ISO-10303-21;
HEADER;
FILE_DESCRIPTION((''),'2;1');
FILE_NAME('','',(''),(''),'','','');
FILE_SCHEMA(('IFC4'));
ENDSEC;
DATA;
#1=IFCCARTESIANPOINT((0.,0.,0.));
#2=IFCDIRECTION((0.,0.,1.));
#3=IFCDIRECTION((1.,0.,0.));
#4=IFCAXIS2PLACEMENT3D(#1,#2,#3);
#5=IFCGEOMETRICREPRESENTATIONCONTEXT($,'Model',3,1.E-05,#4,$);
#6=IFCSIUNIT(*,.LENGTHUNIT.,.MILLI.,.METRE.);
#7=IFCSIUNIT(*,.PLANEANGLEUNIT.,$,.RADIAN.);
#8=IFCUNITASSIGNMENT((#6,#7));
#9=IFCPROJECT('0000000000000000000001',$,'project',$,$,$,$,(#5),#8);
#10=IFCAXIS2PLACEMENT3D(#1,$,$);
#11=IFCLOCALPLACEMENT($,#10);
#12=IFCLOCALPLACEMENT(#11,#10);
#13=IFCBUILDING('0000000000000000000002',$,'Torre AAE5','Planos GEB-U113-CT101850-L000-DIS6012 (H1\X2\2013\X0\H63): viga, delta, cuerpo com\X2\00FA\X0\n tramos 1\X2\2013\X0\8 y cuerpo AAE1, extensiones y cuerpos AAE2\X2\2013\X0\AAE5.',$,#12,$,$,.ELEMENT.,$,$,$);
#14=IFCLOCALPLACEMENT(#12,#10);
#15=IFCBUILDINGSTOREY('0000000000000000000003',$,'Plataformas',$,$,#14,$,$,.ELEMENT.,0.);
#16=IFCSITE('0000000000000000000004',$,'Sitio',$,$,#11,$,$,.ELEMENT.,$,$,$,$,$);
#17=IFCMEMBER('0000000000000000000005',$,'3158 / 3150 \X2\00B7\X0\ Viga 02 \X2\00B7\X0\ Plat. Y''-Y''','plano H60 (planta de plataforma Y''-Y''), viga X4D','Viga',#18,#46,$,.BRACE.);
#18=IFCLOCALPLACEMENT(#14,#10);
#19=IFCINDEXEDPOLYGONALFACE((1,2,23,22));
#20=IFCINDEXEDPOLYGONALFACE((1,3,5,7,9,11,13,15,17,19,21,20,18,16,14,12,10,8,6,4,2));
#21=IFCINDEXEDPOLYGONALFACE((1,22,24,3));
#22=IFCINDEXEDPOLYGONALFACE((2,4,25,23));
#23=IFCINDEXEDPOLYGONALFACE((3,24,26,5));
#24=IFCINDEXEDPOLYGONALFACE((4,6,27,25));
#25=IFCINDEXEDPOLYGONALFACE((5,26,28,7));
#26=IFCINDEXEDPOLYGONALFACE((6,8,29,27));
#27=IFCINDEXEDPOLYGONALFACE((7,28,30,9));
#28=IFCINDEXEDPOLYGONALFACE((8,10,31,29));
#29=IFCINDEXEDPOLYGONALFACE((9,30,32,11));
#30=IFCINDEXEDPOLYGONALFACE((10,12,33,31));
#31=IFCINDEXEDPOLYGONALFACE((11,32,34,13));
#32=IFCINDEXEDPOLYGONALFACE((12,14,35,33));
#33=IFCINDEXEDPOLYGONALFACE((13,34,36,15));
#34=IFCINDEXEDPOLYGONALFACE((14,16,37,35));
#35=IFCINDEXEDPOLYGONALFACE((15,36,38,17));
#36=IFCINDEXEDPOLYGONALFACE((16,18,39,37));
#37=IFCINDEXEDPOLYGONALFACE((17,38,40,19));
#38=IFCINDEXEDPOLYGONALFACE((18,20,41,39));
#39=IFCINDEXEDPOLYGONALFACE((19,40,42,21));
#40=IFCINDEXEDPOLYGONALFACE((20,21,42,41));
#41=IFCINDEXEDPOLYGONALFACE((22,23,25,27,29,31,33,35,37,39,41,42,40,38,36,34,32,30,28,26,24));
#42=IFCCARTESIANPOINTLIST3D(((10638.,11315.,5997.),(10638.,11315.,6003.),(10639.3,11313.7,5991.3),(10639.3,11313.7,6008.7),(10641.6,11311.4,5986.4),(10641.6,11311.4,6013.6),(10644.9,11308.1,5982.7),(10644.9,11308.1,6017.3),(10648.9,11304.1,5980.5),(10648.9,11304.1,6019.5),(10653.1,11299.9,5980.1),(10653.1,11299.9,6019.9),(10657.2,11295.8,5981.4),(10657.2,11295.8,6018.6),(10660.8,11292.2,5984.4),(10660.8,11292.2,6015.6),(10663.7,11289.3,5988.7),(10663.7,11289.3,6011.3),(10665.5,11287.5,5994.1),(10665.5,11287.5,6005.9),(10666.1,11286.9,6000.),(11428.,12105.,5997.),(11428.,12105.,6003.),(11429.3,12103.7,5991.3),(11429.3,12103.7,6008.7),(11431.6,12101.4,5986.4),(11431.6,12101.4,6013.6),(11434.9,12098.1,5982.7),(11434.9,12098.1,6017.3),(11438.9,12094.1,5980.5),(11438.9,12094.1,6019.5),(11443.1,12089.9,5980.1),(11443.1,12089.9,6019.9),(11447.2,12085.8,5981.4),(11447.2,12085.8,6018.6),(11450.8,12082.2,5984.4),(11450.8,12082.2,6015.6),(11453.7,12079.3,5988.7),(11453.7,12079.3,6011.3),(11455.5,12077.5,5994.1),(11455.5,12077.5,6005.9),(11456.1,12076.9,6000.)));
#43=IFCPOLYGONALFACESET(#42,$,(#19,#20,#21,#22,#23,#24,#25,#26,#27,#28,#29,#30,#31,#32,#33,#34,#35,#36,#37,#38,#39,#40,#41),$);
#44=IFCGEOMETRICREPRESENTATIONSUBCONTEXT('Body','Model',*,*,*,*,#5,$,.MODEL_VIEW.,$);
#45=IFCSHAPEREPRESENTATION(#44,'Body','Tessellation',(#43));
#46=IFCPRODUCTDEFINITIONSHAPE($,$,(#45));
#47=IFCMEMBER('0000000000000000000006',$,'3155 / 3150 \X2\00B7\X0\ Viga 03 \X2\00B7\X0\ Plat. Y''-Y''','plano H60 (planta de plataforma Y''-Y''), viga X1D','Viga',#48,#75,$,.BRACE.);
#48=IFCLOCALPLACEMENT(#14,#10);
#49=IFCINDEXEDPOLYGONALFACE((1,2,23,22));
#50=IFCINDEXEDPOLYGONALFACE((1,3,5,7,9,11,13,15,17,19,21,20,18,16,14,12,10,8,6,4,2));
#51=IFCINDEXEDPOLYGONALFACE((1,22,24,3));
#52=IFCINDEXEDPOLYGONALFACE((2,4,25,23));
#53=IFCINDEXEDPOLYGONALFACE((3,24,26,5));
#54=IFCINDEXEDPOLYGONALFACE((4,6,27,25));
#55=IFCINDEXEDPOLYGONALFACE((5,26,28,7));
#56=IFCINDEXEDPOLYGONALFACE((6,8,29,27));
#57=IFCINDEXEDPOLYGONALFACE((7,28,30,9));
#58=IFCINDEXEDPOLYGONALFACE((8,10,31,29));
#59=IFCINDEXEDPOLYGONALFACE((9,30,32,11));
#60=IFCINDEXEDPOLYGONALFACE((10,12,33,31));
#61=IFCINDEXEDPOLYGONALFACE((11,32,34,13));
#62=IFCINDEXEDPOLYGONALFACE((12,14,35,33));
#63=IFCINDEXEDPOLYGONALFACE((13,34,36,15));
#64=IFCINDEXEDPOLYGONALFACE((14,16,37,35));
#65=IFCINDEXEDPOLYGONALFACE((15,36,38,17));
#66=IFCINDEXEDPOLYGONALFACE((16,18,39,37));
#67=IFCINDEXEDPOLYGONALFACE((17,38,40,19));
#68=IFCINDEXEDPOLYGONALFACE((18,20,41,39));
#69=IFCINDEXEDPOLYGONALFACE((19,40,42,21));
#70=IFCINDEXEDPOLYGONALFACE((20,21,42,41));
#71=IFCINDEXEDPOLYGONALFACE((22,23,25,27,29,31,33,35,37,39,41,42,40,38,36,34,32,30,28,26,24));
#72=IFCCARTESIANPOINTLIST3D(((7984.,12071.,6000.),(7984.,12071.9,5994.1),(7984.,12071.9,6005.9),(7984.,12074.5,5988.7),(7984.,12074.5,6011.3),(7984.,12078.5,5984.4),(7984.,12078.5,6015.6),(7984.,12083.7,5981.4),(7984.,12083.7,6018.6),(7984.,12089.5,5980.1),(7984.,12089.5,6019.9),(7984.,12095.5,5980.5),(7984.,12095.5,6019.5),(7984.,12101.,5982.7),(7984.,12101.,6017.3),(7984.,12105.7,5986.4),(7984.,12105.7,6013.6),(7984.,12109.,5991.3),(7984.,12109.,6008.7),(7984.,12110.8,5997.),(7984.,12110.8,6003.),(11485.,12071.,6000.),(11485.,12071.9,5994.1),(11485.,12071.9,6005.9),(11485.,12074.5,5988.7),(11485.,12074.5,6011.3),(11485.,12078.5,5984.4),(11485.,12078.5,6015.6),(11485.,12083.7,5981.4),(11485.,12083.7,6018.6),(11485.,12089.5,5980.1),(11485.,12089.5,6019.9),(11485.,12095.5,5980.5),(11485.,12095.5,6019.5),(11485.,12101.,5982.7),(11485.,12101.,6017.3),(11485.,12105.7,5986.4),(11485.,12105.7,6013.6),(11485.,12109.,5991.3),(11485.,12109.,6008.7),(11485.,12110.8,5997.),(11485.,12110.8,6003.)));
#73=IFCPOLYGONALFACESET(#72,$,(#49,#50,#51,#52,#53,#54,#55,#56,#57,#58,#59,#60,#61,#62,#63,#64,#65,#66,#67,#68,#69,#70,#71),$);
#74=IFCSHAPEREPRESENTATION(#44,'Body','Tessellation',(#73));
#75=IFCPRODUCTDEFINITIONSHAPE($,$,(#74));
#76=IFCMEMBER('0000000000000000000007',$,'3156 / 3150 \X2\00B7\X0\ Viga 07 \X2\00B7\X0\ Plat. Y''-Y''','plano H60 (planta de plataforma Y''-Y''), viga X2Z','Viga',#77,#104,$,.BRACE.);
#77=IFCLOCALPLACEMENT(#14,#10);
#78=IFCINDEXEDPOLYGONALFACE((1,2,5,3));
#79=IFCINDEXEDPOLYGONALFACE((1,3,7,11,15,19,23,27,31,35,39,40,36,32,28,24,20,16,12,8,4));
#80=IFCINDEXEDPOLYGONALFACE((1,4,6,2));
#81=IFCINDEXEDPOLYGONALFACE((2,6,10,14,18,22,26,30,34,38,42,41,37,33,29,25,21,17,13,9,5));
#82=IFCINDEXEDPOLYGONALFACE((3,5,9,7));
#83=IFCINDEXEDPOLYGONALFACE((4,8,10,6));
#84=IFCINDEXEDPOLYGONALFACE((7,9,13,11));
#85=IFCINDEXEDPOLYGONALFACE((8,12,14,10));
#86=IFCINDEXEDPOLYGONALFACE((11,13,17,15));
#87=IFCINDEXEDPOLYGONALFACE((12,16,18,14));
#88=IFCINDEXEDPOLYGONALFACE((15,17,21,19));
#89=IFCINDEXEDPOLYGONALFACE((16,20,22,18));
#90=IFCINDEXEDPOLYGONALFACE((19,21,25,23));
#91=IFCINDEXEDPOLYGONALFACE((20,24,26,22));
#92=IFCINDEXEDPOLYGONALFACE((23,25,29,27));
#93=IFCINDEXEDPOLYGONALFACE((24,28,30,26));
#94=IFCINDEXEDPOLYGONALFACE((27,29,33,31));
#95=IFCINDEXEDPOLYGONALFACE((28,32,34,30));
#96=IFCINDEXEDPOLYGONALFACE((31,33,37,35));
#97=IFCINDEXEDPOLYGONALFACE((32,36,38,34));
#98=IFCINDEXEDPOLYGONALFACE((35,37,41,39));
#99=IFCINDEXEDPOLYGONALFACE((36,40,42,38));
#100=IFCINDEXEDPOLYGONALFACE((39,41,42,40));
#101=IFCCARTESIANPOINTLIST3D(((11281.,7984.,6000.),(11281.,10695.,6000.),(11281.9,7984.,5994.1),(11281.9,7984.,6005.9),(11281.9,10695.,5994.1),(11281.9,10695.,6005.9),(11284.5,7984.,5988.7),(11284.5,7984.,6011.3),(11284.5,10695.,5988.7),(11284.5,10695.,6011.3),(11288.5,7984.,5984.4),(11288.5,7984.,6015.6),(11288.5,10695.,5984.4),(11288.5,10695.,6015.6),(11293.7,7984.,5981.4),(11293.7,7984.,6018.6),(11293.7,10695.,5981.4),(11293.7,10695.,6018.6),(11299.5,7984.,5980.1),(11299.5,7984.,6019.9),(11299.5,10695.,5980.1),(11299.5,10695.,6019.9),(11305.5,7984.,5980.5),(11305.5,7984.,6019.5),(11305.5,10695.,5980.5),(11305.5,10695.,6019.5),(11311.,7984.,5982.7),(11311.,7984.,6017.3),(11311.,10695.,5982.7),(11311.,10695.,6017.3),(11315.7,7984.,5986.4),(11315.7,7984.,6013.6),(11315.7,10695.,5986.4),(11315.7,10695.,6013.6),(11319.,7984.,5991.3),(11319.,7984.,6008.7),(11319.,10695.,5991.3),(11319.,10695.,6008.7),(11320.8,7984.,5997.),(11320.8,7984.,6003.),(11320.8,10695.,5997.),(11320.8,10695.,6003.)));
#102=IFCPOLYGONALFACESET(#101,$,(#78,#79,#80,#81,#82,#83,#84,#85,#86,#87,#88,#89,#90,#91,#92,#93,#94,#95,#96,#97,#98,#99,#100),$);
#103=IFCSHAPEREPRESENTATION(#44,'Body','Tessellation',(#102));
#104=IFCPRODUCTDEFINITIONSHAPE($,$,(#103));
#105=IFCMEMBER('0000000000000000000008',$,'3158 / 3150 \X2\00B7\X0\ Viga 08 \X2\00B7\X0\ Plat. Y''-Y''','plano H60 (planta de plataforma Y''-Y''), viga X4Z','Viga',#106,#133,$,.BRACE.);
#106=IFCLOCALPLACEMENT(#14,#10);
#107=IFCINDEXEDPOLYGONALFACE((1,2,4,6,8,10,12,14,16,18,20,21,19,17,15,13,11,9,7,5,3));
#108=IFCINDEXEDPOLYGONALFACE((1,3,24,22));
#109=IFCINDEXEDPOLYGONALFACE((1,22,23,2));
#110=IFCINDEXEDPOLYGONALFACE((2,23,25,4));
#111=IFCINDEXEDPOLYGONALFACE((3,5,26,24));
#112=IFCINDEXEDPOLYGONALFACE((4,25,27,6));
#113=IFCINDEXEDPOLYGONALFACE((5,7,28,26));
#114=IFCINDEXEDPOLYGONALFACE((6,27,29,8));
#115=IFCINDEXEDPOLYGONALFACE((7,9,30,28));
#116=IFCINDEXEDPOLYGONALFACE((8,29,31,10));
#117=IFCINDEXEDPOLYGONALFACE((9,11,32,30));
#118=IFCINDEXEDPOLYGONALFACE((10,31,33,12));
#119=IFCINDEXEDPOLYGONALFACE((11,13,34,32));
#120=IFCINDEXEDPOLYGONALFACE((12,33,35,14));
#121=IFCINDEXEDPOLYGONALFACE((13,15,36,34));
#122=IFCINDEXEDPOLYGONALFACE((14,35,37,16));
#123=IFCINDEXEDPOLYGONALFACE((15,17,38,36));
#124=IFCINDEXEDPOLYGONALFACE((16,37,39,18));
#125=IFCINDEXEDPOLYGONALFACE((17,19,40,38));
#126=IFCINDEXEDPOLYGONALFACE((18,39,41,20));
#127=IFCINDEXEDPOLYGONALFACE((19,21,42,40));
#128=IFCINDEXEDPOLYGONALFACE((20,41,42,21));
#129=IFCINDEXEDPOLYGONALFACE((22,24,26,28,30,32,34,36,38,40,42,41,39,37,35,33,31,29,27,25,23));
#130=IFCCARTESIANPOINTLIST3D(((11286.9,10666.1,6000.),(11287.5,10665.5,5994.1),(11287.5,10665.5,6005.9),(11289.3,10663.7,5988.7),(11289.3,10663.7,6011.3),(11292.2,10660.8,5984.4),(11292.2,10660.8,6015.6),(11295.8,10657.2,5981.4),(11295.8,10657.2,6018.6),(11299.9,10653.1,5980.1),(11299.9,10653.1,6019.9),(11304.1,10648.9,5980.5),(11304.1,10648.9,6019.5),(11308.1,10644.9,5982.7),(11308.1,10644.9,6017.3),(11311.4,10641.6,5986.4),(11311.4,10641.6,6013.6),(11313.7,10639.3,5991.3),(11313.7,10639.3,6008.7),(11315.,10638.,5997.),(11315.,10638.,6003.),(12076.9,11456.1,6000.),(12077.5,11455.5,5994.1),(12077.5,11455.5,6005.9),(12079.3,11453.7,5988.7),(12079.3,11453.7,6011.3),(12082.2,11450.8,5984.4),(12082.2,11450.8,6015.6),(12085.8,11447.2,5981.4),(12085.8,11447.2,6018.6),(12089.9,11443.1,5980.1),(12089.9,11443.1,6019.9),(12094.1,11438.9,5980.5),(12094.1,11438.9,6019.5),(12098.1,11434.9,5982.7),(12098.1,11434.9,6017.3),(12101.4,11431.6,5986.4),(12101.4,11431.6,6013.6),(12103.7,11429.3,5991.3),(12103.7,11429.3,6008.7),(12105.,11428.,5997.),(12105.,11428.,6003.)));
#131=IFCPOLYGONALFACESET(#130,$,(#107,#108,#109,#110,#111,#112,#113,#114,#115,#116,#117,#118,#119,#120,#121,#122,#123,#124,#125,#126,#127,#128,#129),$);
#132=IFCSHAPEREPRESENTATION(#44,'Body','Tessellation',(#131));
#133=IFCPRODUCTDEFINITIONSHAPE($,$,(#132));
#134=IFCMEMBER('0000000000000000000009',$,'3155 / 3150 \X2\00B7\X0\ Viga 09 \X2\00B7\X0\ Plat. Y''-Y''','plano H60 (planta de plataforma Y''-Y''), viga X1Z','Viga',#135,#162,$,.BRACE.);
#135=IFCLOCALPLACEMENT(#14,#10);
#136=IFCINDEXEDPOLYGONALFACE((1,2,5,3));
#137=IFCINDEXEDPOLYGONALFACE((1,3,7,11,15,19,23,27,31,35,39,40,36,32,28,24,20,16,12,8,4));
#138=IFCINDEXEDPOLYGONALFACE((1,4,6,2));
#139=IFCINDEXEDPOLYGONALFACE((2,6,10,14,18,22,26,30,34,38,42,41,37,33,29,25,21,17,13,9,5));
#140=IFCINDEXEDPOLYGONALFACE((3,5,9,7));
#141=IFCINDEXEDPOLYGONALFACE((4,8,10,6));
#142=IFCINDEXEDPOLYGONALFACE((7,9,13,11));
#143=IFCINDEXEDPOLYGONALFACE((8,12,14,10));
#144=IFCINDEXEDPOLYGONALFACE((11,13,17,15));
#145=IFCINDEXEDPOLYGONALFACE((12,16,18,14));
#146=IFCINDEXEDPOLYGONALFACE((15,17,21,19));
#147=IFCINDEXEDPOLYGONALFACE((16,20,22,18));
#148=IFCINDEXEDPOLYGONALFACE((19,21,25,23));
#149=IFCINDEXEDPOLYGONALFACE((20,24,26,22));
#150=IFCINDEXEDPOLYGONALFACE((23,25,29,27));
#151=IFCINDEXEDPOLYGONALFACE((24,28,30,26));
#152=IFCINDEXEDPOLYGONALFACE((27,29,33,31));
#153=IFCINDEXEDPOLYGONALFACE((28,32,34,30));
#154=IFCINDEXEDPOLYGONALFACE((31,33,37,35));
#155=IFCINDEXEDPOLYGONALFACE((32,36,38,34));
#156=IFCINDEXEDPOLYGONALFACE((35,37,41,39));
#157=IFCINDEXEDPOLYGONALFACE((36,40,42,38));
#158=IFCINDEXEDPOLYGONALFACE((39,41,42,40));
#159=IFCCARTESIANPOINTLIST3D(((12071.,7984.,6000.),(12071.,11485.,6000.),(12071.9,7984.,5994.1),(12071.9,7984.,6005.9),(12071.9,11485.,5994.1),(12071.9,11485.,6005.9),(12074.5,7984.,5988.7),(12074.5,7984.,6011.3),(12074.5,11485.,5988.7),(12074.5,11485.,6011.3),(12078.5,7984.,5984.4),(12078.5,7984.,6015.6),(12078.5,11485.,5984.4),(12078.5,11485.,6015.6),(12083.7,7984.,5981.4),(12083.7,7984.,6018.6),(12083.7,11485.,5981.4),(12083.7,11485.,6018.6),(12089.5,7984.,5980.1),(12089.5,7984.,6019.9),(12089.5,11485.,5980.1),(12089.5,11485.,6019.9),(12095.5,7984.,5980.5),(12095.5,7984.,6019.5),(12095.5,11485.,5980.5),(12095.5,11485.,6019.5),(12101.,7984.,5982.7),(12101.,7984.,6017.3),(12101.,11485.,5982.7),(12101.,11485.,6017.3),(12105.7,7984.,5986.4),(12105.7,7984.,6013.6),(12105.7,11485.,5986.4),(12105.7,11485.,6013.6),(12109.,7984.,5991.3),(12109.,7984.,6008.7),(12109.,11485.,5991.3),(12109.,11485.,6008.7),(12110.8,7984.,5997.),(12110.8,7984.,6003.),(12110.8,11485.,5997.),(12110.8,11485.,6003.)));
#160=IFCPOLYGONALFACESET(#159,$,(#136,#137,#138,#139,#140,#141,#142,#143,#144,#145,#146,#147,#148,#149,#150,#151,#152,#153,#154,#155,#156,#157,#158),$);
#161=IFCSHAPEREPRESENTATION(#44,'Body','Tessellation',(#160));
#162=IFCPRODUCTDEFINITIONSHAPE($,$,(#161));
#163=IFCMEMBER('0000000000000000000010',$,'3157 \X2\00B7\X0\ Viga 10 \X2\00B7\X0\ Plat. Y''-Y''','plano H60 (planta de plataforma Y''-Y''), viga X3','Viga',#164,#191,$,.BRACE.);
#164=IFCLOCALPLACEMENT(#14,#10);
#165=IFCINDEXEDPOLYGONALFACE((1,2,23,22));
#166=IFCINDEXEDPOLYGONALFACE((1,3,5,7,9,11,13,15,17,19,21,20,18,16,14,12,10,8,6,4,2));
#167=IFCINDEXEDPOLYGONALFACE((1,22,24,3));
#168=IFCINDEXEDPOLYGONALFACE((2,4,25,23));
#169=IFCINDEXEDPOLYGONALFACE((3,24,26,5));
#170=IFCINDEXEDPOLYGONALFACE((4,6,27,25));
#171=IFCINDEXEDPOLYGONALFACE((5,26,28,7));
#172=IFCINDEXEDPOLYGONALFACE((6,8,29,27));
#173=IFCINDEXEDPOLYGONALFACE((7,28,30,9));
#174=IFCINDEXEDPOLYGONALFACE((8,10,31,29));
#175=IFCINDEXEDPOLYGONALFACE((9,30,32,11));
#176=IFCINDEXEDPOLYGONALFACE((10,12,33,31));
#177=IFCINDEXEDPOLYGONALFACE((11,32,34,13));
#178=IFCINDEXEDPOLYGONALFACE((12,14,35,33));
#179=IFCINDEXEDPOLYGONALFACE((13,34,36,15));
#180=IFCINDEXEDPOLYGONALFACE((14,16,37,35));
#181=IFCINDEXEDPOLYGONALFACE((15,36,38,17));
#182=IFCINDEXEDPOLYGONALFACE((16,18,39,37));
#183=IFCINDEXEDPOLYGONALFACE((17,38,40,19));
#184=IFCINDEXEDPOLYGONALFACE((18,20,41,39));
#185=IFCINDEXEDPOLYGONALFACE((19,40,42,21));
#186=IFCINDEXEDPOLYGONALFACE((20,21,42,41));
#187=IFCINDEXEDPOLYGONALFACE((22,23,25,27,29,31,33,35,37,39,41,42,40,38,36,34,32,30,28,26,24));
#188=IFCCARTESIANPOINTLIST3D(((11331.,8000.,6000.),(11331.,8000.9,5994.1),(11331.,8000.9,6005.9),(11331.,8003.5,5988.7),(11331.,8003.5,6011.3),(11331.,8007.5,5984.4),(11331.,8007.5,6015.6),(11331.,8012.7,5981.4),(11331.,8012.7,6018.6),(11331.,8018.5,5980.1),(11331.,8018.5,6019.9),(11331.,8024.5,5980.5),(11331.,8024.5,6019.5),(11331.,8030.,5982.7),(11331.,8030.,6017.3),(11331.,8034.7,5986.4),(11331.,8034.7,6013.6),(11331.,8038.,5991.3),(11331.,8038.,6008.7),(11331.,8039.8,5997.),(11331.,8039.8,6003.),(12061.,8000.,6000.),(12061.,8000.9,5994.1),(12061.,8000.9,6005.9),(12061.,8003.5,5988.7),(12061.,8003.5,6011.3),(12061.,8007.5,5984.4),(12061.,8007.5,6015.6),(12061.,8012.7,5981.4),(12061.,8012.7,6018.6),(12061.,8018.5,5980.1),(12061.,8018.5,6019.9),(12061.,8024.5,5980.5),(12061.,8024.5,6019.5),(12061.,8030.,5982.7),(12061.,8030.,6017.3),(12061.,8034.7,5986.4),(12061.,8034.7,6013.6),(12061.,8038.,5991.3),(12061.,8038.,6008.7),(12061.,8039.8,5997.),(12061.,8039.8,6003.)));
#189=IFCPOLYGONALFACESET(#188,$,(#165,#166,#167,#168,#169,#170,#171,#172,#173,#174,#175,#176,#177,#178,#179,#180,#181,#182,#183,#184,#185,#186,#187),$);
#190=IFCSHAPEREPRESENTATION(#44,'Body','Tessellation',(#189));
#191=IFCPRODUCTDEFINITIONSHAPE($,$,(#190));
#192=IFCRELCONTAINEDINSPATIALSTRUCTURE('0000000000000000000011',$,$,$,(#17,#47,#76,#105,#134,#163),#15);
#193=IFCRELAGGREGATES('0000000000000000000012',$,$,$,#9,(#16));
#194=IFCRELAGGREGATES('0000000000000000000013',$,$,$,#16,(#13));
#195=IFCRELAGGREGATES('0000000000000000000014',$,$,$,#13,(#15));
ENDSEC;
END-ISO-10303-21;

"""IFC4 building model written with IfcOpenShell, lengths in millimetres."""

from ifc_helpers import new_model, si_unit, frame, origin, origin_with_axes, place, context, subcontext, project, spatial, circle, extrude, element, save


model = new_model("IFC4")

# Units and contexts
model_context = context("Model", 3, precision=1e-05, world=origin_with_axes())
body_context = subcontext(model_context, "Body", "Model", "MODEL_VIEW")
ifc_project = project(units=[si_unit("LENGTHUNIT", "METRE", prefix="MILLI"), si_unit("PLANEANGLEUNIT", "RADIAN")], contexts=[model_context])

# Site, building, storey
site_placement = place(None, origin())
site = spatial("IfcSite", under=ifc_project, at=site_placement, Name="Sitio", CompositionType="ELEMENT")
building_placement = place(site_placement, origin())
building = spatial("IfcBuilding", under=site, at=building_placement, Name="Torre AAE5", Description="Planos GEB-U113-CT101850-L000-DIS6012 (H1–H63): viga, delta, cuerpo común tramos 1–8 y cuerpo AAE1, extensiones y cuerpos AAE2–AAE5.", CompositionType="ELEMENT")
storey_placement = place(building_placement, origin())
storey = spatial("IfcBuildingStorey", under=building, at=storey_placement, Name="Plataformas", CompositionType="ELEMENT", Elevation=0.0)

# Members
member_1_placement = place(storey_placement, frame((11442.0, 12091.0, 6000.0), z_axis=(-0.707107, -0.707107, 0.0), x_axis=(0.707107, -0.707107, 0.0)))
element("IfcMember", 1, at=member_1_placement, inside=storey, Name="3158 / 3150 · Viga 02 · Plat. Y'-Y'", Description="plano H60 (planta de plataforma Y'-Y'), viga X4D", ObjectType="Viga", PredefinedType="BRACE", context=body_context, shape_type="SweptSolid", body=[
    extrude(circle(Radius=20.0), None, (0.0, 0.0, 1.0), 1117.2),
])
member_2_placement = place(storey_placement, frame((11485.0, 12091.0, 6000.0), z_axis=(-1.0, 0.0, 0.0), x_axis=(0.0, -1.0, 0.0)))
element("IfcMember", 2, at=member_2_placement, inside=storey, Name="3155 / 3150 · Viga 03 · Plat. Y'-Y'", Description="plano H60 (planta de plataforma Y'-Y'), viga X1D", ObjectType="Viga", PredefinedType="BRACE", context=body_context, shape_type="SweptSolid", body=[
    extrude(circle(Radius=20.0), None, (0.0, 0.0, 1.0), 3501.0),
])
member_3_placement = place(storey_placement, frame((11301.0, 7984.0, 6000.0), z_axis=(0.0, 1.0, 0.0), x_axis=(-1.0, 0.0, 0.0)))
element("IfcMember", 3, at=member_3_placement, inside=storey, Name="3156 / 3150 · Viga 07 · Plat. Y'-Y'", Description="plano H60 (planta de plataforma Y'-Y'), viga X2Z", ObjectType="Viga", PredefinedType="BRACE", context=body_context, shape_type="SweptSolid", body=[
    extrude(circle(Radius=20.0), None, (0.0, 0.0, 1.0), 2711.0),
])
member_4_placement = place(storey_placement, frame((12091.0, 11442.0, 6000.0), z_axis=(-0.707107, -0.707107, 0.0), x_axis=(-0.707107, 0.707107, 0.0)))
element("IfcMember", 4, at=member_4_placement, inside=storey, Name="3158 / 3150 · Viga 08 · Plat. Y'-Y'", Description="plano H60 (planta de plataforma Y'-Y'), viga X4Z", ObjectType="Viga", PredefinedType="BRACE", context=body_context, shape_type="SweptSolid", body=[
    extrude(circle(Radius=20.0), None, (0.0, 0.0, 1.0), 1117.2),
])
member_5_placement = place(storey_placement, frame((12091.0, 11485.0, 6000.0), z_axis=(0.0, -1.0, 0.0), x_axis=(-1.0, 0.0, 0.0)))
element("IfcMember", 5, at=member_5_placement, inside=storey, Name="3155 / 3150 · Viga 09 · Plat. Y'-Y'", Description="plano H60 (planta de plataforma Y'-Y'), viga X1Z", ObjectType="Viga", PredefinedType="BRACE", context=body_context, shape_type="SweptSolid", body=[
    extrude(circle(Radius=20.0), None, (0.0, 0.0, 1.0), 3501.0),
])
for number, where, z_axis, x_axis, name in (
    (6, (12061.0, 8020.0, 6000.0), (-1.0, 0.0, 0.0), (0.0, -1.0, 0.0), "3157 · Viga 10 · Plat. Y'-Y'"),
):
    element("IfcMember", number, at=place(storey_placement, frame(where, z_axis=z_axis, x_axis=x_axis)), inside=storey, Name=name, Description="plano H60 (planta de plataforma Y'-Y'), viga X3", ObjectType="Viga", PredefinedType="BRACE", context=body_context, shape_type="SweptSolid", body=[
        extrude(circle(Radius=20.0), None, (0.0, 0.0, 1.0), 730.0),
    ])

save(model, "model.ifc")
